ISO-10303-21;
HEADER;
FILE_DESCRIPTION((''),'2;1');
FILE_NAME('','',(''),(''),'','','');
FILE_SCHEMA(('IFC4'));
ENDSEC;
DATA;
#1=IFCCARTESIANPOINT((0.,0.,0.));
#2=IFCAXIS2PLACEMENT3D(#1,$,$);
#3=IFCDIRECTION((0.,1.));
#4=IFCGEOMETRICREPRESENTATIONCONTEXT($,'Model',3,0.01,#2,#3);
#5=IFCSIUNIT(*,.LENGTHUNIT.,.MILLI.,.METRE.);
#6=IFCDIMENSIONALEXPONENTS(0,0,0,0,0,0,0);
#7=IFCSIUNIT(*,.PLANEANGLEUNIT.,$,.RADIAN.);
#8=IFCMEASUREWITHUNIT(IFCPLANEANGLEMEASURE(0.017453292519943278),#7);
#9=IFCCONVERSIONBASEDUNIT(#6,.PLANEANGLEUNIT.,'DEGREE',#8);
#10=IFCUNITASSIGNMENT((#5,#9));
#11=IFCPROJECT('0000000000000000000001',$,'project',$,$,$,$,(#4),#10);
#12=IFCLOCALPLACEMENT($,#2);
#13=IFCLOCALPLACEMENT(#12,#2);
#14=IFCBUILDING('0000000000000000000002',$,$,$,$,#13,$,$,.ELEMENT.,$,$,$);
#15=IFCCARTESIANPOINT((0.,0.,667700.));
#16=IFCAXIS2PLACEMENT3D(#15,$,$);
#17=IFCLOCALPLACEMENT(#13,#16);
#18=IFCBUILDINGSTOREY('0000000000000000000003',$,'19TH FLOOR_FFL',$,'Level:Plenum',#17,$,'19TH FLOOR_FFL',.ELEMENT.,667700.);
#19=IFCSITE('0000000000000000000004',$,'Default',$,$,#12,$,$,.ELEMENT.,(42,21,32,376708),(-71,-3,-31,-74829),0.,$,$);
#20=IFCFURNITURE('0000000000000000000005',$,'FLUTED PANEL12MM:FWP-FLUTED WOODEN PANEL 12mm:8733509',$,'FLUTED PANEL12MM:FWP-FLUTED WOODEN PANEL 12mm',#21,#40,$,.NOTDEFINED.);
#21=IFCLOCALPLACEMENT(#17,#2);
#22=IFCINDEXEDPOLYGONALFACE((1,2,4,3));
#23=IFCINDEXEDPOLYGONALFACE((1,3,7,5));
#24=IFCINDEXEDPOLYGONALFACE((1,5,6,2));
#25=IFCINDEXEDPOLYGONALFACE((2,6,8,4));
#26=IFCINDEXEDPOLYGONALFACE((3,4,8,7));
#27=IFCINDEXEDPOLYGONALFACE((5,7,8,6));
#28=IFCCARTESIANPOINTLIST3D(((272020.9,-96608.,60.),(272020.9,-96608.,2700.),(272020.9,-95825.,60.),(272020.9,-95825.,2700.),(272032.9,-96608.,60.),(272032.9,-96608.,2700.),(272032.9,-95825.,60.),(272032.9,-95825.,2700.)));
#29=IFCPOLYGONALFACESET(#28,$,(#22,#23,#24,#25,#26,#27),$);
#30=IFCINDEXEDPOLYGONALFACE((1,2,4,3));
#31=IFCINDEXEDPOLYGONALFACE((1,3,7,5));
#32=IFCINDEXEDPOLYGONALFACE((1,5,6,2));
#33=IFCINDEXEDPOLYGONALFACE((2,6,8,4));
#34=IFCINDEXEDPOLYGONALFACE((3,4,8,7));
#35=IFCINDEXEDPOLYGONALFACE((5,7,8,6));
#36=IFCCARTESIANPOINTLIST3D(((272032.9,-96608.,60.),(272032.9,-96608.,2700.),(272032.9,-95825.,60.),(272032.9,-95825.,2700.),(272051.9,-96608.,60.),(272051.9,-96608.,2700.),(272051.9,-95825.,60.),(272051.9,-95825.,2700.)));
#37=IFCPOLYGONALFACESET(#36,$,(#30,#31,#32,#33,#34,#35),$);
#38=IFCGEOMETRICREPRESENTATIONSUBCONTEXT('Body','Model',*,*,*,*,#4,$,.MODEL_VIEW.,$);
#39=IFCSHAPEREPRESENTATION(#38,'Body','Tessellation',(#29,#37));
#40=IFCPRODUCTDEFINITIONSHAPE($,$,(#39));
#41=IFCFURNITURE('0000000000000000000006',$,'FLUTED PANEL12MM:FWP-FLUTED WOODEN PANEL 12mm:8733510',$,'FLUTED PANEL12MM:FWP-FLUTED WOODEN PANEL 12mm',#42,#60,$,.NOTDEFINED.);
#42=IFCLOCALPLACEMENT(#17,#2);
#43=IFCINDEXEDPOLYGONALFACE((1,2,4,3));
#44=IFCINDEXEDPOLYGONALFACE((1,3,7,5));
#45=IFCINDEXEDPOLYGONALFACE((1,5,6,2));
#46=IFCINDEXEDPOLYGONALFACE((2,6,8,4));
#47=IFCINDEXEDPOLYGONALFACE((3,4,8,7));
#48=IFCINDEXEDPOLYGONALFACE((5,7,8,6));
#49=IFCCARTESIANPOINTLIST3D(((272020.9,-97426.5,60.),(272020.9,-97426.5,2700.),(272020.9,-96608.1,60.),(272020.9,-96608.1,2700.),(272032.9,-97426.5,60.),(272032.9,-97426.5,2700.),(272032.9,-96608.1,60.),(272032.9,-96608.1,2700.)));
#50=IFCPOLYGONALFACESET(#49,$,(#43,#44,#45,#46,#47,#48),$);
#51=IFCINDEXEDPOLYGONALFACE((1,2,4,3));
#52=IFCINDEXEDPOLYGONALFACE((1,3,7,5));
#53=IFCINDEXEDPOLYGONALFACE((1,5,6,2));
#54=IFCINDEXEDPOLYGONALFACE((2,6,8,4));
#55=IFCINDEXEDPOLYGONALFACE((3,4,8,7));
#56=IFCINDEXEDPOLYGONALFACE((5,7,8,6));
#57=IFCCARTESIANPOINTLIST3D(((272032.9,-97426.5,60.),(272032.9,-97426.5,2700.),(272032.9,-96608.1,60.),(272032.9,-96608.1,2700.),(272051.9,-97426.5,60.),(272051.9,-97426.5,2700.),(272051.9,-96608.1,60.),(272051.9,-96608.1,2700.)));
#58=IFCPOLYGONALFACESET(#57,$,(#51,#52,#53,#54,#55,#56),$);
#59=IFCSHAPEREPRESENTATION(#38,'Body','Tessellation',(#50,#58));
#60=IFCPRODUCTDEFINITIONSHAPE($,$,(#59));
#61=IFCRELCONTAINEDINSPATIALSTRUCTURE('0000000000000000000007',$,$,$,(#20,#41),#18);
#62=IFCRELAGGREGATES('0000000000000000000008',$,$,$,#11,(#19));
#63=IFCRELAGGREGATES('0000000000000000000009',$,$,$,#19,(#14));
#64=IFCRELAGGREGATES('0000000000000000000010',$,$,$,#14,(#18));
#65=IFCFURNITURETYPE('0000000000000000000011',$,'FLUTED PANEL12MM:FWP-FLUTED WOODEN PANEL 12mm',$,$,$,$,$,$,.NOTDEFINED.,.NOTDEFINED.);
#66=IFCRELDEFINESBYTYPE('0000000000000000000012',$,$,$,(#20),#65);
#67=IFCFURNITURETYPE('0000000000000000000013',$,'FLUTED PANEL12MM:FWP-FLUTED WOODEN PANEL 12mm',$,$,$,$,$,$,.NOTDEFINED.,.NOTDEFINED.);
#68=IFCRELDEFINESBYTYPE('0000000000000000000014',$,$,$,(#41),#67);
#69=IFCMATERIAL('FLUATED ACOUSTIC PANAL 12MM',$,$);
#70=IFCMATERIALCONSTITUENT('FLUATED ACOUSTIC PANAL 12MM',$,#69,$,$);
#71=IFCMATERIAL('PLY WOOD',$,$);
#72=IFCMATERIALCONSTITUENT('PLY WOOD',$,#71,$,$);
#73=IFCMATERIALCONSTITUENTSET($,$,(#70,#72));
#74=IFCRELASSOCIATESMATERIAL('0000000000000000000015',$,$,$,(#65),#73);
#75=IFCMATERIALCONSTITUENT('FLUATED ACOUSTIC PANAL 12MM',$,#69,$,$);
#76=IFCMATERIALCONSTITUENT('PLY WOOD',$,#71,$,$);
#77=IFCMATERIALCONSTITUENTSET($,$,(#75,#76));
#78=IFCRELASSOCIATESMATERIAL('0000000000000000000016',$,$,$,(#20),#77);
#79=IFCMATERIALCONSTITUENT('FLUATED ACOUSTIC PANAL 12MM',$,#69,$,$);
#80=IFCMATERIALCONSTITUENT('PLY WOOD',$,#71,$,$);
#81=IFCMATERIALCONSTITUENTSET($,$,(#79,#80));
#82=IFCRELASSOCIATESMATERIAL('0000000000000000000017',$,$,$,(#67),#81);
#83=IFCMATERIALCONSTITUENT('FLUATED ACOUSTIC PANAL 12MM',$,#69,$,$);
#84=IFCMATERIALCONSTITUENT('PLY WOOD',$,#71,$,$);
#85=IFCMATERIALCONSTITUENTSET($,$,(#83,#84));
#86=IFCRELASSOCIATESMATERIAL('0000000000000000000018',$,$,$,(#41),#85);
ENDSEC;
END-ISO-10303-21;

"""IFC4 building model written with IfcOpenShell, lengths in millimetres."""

from ifc_helpers import new_model, entity, si_unit, converted_unit, direction, frame, origin, place, context, subcontext, project, spatial, indexed_curve, outline, extrude, source, transform, mapped, material, constituent, constituent_set, type_object, type_shapes, element, save


model = new_model("IFC4")

# Units and contexts
model_context = context("Model", 3, precision=0.01, world=origin(), true_north=direction((0.0, 1.0)))
body_context = subcontext(model_context, "Body", "Model", "MODEL_VIEW")
ifc_project = project(units=[si_unit("LENGTHUNIT", "METRE", prefix="MILLI"), converted_unit("PLANEANGLEUNIT", "DEGREE", entity("IfcPlaneAngleMeasure", 0.017453292519943278), si_unit("PLANEANGLEUNIT", "RADIAN"), dimensions=[0, 0, 0, 0, 0, 0, 0])], contexts=[model_context])

# Site, building, storey
site_placement = place(None, origin())
site = spatial("IfcSite", under=ifc_project, at=site_placement, Name="Default", CompositionType="ELEMENT", RefLatitude=(42, 21, 32, 376708), RefLongitude=(-71, -3, -31, -74829), RefElevation=0.0)
building_placement = place(site_placement, origin())
building = spatial("IfcBuilding", under=site, at=building_placement, CompositionType="ELEMENT")
storey_placement = place(building_placement, frame((0.0, 0.0, 667700.0)))
storey = spatial("IfcBuildingStorey", under=building, at=storey_placement, Name="19TH FLOOR_FFL", ObjectType="Level:Plenum", LongName="19TH FLOOR_FFL", CompositionType="ELEMENT", Elevation=667700.0)

# Furniture
ifc_material_1 = material(Name="FLUATED ACOUSTIC PANAL 12MM")
ifc_constituent_1 = constituent(ifc_material_1, Name="FLUATED ACOUSTIC PANAL 12MM")
ifc_material_2 = material(Name="PLY WOOD")
ifc_constituent_2 = constituent(ifc_material_2, Name="PLY WOOD")
ifc_constituent_set_1 = constituent_set(constituents=[ifc_constituent_1, ifc_constituent_2])
ifc_constituent_3 = constituent(ifc_material_1, Name="FLUATED ACOUSTIC PANAL 12MM")
ifc_constituent_4 = constituent(ifc_material_2, Name="PLY WOOD")
ifc_constituent_set_2 = constituent_set(constituents=[ifc_constituent_3, ifc_constituent_4])
furniture_type_1 = type_object("IfcFurnitureType", Name="FLUTED PANEL12MM:FWP-FLUTED WOODEN PANEL 12mm", AssemblyPlace="NOTDEFINED", PredefinedType="NOTDEFINED", material=ifc_constituent_set_2)
shared_shape_1 = source(origin(), body_context, "Body", "SweptSolid", [
    extrude(outline(indexed_curve([(-391.5, -1320.0), (391.5, -1320.0), (391.5, 1320.0), (-391.5, 1320.0), (-391.5, -1320.0)], self_intersect=False)), frame((0.0, 1320.0, 19.0), z_axis=(0.0, 0.0, 1.0), x_axis=(-1.0, 0.0, 0.0)), (0.0, 0.0, 1.0), 12.0),
    extrude(outline(indexed_curve([(-1320.0, -391.5), (1320.0, -391.5), (1320.0, 391.5), (-1320.0, 391.5), (-1320.0, -391.5)], self_intersect=False)), frame((0.0, 1320.0, 0.0), z_axis=(0.0, 0.0, 1.0), x_axis=(0.0, -1.0, 0.0)), (0.0, 0.0, 1.0), 19.0),
])
type_shapes(furniture_type_1, [shared_shape_1])
furniture_1_placement = place(storey_placement, frame((272051.9, -96216.5, 60.0), z_axis=(-1.0, 0.0, 0.0), x_axis=(0.0, -1.0, 0.0)))
element("IfcFurniture", 1, at=furniture_1_placement, inside=storey, type_object=furniture_type_1, material=ifc_constituent_set_1, Name="FLUTED PANEL12MM:FWP-FLUTED WOODEN PANEL 12mm:8733509", ObjectType="FLUTED PANEL12MM:FWP-FLUTED WOODEN PANEL 12mm", PredefinedType="NOTDEFINED", context=body_context, shape_type="MappedRepresentation", body=[
    mapped(shared_shape_1, transform((0.0, 0.0, 0.0), scale=1.0)),
])
ifc_constituent_5 = constituent(ifc_material_1, Name="FLUATED ACOUSTIC PANAL 12MM")
ifc_constituent_6 = constituent(ifc_material_2, Name="PLY WOOD")
ifc_constituent_set_3 = constituent_set(constituents=[ifc_constituent_5, ifc_constituent_6])
ifc_constituent_7 = constituent(ifc_material_1, Name="FLUATED ACOUSTIC PANAL 12MM")
ifc_constituent_8 = constituent(ifc_material_2, Name="PLY WOOD")
ifc_constituent_set_4 = constituent_set(constituents=[ifc_constituent_7, ifc_constituent_8])
furniture_type_2 = type_object("IfcFurnitureType", Name="FLUTED PANEL12MM:FWP-FLUTED WOODEN PANEL 12mm", AssemblyPlace="NOTDEFINED", PredefinedType="NOTDEFINED", material=ifc_constituent_set_4)
shared_shape_2 = source(origin(), body_context, "Body", "SweptSolid", [
    extrude(outline(indexed_curve([(-409.2, -1320.0), (409.2, -1320.0), (409.2, 1320.0), (-409.2, 1320.0), (-409.2, -1320.0)], self_intersect=False)), frame((0.0, 1320.0, 19.0), z_axis=(0.0, 0.0, 1.0), x_axis=(-1.0, 0.0, 0.0)), (0.0, 0.0, 1.0), 12.0),
    extrude(outline(indexed_curve([(-1320.0, -409.2), (1320.0, -409.2), (1320.0, 409.2), (-1320.0, 409.2), (-1320.0, -409.2)], self_intersect=False)), frame((0.0, 1320.0, 0.0), z_axis=(0.0, 0.0, 1.0), x_axis=(0.0, -1.0, 0.0)), (0.0, 0.0, 1.0), 19.0),
])
type_shapes(furniture_type_2, [shared_shape_2])
furniture_2_placement = place(storey_placement, frame((272051.9, -97017.3, 60.0), z_axis=(-1.0, 0.0, 0.0), x_axis=(0.0, -1.0, 0.0)))
element("IfcFurniture", 2, at=furniture_2_placement, inside=storey, type_object=furniture_type_2, material=ifc_constituent_set_3, Name="FLUTED PANEL12MM:FWP-FLUTED WOODEN PANEL 12mm:8733510", ObjectType="FLUTED PANEL12MM:FWP-FLUTED WOODEN PANEL 12mm", PredefinedType="NOTDEFINED", context=body_context, shape_type="MappedRepresentation", body=[
    mapped(shared_shape_2, transform((0.0, 0.0, 0.0), scale=1.0)),
])

save(model, "model.ifc")
